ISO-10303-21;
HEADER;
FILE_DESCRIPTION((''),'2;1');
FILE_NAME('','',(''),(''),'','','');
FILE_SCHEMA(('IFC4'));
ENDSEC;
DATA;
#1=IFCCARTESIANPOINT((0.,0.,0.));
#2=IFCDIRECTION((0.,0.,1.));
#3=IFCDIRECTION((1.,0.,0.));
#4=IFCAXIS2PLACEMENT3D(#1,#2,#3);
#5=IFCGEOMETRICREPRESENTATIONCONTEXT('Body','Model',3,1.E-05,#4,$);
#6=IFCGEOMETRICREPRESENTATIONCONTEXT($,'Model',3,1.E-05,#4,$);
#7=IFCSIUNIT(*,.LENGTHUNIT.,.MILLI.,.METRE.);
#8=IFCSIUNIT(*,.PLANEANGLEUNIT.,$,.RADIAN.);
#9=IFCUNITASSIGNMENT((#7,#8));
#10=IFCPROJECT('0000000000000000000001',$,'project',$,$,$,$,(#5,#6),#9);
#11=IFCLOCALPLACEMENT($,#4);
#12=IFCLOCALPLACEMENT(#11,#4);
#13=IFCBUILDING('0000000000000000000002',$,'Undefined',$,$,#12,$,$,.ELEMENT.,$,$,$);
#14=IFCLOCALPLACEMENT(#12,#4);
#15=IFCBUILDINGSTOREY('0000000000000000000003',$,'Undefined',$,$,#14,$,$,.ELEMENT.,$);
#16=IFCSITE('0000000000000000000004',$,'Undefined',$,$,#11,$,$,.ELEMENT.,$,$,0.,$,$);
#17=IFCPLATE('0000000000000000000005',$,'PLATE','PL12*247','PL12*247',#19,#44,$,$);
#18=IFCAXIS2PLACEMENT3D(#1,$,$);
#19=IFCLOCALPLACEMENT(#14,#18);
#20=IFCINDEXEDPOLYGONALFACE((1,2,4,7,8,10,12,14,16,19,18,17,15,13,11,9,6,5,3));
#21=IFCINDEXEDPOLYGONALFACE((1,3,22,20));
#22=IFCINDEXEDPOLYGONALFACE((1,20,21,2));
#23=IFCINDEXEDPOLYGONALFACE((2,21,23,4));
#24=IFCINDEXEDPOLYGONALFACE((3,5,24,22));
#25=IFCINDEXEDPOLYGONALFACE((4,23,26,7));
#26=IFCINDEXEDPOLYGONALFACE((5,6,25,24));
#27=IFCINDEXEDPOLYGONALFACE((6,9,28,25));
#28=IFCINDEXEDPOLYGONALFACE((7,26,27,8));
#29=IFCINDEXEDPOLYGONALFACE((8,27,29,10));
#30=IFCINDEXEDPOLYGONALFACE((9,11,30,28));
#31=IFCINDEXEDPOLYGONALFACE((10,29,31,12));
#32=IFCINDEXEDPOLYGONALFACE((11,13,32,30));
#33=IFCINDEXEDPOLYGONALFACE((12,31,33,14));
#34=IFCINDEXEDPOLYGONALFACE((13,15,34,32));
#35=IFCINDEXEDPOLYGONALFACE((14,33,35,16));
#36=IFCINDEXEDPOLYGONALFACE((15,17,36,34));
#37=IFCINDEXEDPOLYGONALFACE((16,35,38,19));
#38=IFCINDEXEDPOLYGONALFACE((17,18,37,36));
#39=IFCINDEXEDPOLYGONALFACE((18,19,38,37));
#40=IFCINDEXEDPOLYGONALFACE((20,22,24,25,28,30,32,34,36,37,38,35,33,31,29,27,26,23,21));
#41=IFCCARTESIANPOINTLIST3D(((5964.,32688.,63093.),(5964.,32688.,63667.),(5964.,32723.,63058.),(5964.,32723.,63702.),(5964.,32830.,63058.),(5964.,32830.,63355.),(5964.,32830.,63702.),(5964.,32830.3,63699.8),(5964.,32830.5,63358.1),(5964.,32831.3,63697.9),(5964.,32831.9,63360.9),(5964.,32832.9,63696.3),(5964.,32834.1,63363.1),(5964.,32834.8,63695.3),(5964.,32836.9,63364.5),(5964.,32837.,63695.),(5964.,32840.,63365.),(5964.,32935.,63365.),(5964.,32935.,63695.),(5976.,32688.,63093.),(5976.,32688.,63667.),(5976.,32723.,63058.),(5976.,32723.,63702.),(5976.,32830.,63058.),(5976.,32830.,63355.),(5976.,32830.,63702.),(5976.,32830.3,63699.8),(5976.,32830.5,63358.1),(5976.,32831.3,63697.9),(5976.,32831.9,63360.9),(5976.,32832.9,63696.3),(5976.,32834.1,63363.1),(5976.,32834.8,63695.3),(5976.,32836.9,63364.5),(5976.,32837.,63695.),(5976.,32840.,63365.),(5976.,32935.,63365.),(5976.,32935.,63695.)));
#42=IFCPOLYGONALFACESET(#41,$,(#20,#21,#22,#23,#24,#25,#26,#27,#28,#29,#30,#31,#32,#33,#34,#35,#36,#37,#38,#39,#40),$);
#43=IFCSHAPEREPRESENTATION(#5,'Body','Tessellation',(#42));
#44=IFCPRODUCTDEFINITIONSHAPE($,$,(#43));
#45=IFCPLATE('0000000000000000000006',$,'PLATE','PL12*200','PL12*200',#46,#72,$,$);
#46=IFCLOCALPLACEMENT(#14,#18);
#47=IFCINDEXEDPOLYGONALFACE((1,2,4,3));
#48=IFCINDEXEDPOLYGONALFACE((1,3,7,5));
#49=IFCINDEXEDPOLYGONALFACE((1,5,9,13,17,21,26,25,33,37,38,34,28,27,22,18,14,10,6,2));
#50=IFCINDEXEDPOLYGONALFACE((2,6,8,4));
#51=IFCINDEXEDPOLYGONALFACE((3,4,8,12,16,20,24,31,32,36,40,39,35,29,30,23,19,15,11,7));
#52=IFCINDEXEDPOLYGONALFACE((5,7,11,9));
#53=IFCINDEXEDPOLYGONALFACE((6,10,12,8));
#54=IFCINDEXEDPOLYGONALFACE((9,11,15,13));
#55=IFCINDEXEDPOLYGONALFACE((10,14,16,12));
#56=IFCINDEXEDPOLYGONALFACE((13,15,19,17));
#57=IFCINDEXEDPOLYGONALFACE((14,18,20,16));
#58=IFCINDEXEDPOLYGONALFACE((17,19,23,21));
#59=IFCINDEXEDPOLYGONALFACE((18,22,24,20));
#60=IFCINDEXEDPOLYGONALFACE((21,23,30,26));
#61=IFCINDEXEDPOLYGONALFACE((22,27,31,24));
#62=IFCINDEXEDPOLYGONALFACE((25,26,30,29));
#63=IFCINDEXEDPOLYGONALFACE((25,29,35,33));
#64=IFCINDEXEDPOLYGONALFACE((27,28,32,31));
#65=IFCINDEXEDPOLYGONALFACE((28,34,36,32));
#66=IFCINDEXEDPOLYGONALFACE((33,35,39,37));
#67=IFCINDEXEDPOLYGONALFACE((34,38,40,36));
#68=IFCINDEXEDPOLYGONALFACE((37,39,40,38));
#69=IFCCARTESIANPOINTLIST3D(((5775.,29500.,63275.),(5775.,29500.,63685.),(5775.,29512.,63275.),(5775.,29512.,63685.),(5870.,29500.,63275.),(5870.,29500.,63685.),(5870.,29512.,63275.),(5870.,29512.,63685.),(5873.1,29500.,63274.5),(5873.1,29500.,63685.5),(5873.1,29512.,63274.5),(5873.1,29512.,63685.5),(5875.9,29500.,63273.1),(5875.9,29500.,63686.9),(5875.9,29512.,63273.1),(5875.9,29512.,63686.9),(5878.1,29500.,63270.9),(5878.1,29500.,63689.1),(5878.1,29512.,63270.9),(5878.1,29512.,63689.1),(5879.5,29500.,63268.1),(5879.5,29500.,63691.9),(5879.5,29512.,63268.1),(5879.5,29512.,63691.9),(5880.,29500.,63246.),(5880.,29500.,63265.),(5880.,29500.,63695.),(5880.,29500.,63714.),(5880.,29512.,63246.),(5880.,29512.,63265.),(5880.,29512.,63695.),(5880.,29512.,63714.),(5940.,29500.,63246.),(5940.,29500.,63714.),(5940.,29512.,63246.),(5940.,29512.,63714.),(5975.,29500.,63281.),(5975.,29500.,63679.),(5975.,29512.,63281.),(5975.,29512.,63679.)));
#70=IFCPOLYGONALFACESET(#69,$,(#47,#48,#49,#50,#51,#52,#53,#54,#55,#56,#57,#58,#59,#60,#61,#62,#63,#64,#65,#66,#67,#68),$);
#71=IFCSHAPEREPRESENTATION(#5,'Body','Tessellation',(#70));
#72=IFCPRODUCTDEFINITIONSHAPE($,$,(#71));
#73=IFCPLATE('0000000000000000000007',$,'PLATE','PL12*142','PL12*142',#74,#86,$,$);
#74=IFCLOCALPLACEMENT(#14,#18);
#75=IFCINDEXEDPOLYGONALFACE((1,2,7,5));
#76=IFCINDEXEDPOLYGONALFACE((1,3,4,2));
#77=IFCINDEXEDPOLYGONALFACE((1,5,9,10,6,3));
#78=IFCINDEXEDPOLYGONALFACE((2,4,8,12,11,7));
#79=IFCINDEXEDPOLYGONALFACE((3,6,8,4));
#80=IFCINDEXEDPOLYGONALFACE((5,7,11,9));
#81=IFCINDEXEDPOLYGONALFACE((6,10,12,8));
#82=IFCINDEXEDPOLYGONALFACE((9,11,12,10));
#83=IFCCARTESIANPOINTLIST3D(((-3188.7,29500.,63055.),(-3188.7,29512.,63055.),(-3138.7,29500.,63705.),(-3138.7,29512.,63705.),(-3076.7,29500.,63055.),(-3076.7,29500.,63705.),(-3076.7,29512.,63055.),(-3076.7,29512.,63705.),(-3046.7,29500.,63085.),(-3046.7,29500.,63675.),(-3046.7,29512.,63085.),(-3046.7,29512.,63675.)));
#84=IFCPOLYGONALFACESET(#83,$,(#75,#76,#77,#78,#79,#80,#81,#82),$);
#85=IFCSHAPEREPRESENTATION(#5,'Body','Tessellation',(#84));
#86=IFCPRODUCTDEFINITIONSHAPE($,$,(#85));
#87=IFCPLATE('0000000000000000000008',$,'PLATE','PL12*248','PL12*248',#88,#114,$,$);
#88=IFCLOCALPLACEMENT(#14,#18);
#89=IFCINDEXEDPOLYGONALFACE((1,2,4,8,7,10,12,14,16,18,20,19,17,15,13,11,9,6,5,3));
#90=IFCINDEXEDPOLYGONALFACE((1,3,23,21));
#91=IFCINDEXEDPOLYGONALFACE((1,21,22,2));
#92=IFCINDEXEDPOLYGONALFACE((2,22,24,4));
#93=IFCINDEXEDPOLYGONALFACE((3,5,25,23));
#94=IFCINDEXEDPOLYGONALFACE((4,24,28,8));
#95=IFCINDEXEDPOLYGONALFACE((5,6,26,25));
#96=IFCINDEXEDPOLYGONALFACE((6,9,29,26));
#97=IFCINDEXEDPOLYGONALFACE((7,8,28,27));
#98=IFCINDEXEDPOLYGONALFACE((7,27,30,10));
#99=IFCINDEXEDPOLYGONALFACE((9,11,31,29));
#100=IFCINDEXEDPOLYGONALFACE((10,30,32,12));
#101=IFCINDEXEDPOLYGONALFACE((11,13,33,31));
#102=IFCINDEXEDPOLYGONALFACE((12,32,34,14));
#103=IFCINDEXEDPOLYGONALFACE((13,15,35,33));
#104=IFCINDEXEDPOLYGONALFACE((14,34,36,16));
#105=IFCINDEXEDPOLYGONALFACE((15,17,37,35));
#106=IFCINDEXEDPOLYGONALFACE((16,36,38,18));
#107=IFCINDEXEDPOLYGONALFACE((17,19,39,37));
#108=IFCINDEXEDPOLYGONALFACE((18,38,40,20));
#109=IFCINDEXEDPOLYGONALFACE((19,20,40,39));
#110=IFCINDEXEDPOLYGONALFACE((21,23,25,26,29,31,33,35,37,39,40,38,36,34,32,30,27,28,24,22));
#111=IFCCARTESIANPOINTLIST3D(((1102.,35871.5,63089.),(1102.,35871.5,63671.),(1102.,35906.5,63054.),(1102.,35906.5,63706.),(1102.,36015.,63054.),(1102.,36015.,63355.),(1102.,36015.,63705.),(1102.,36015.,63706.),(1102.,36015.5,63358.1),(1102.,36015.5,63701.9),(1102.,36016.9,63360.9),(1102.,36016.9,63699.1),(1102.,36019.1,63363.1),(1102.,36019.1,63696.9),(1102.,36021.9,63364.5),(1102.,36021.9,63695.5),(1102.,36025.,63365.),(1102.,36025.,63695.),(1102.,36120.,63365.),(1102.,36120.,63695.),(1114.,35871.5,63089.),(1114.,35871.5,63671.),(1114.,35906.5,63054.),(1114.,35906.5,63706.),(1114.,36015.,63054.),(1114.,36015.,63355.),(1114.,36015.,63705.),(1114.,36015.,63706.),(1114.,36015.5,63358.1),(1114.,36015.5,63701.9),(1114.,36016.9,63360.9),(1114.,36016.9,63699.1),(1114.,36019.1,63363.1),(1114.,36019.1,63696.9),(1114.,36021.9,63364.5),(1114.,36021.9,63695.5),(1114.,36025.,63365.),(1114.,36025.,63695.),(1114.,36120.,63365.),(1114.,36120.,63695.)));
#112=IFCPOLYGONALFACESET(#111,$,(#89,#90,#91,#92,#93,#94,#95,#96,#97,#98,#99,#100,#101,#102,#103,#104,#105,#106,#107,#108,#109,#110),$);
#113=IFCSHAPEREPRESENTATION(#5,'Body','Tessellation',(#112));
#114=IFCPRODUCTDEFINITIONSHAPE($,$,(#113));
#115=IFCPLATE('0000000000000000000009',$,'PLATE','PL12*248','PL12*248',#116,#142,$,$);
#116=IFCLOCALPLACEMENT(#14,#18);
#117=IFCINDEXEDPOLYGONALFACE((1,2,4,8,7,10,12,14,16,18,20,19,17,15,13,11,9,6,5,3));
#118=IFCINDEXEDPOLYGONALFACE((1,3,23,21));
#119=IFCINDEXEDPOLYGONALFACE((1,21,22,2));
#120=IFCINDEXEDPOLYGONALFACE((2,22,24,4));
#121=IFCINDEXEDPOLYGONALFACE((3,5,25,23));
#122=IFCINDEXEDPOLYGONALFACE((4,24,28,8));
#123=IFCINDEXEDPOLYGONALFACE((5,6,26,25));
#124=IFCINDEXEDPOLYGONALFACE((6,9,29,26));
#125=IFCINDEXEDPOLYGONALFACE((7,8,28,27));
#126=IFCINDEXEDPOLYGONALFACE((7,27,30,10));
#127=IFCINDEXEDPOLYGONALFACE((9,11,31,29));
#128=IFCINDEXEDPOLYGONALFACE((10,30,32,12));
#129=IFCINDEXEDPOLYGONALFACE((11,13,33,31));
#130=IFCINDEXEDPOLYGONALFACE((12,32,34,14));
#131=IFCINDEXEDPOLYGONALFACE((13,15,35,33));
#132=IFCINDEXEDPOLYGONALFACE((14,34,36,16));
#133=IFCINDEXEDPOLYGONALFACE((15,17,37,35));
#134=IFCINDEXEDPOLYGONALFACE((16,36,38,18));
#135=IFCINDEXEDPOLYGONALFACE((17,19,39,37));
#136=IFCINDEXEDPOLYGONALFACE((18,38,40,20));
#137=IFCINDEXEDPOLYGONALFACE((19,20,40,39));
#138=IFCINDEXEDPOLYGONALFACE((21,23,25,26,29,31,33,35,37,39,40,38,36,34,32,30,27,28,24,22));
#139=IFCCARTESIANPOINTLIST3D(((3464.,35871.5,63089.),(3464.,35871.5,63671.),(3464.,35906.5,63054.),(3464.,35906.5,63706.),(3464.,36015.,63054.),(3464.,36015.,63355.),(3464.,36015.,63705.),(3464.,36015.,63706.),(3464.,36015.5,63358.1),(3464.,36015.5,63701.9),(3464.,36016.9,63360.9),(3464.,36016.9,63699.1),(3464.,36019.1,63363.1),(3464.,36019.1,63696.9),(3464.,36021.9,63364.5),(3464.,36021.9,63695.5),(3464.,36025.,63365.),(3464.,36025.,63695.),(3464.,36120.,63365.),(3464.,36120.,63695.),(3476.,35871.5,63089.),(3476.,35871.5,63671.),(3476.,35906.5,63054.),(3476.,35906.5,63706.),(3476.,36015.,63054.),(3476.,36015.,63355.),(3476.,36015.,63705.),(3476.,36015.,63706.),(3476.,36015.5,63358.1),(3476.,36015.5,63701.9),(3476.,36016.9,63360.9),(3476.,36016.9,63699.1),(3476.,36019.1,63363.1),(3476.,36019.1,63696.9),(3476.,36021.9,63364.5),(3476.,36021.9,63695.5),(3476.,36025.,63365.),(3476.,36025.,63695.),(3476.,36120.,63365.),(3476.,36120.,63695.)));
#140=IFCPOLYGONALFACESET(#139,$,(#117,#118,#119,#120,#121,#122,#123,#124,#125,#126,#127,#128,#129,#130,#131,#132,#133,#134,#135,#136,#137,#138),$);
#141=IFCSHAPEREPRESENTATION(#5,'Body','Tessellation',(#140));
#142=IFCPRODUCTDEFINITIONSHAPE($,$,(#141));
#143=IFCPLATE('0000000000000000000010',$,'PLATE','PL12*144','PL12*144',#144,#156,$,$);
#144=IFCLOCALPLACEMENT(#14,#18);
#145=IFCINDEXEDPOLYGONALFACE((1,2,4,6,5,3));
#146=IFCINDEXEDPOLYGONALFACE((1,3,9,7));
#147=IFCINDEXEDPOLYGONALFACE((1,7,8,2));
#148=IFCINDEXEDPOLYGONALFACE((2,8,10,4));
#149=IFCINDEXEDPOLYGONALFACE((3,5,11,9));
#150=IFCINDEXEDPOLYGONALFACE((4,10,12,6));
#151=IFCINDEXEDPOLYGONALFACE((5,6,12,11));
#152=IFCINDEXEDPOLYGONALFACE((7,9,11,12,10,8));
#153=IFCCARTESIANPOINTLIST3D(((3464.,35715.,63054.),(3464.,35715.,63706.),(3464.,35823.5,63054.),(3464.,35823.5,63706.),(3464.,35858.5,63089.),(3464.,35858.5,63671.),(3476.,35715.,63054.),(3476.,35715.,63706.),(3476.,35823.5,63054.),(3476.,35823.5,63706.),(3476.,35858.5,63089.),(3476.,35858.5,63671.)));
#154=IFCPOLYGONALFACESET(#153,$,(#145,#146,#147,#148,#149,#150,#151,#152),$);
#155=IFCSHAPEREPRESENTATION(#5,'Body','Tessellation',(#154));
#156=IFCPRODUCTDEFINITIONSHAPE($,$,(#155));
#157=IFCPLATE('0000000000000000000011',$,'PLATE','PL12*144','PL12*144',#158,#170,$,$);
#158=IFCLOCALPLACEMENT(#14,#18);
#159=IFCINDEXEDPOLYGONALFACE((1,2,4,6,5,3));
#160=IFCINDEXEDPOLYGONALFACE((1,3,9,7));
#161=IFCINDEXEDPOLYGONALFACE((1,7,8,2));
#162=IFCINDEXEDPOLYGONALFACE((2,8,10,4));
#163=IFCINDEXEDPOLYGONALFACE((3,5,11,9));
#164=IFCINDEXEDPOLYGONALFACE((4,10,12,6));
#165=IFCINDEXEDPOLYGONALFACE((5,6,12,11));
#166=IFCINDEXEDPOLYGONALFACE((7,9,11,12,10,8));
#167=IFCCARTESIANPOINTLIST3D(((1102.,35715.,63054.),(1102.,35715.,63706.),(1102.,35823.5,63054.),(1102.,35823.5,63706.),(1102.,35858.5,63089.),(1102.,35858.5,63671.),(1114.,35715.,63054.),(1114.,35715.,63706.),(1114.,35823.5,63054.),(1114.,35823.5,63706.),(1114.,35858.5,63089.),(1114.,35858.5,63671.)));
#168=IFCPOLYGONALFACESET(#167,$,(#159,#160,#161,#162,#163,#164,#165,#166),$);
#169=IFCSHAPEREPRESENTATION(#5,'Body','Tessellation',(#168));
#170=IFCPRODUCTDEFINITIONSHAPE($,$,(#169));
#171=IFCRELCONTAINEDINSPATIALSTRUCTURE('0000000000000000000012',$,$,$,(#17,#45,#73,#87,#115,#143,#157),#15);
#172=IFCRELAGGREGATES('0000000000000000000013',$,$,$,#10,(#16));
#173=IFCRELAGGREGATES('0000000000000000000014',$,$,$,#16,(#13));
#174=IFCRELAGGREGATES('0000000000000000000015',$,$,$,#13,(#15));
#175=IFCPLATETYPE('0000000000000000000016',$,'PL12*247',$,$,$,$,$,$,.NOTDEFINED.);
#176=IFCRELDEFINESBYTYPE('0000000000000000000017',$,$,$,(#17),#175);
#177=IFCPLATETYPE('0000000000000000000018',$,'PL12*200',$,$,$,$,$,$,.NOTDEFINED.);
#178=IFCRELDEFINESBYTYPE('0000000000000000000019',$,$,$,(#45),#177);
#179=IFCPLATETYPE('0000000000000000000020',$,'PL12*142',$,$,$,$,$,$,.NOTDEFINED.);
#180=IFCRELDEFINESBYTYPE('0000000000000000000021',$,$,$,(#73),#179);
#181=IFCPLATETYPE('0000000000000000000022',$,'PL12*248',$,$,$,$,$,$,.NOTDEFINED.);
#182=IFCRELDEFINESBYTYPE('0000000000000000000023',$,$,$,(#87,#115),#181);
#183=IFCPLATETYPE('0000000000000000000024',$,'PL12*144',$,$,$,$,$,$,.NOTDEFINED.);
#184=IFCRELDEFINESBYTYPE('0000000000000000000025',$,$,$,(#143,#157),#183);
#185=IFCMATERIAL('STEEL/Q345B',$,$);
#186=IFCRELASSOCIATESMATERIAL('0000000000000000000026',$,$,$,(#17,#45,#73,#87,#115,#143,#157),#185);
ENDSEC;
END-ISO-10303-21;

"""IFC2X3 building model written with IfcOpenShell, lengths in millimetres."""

from ifc_helpers import new_model, si_unit, frame, origin_with_axes, place, context, project, spatial, polyline, outline, extrude, material, type_object, element, save


model = new_model("IFC2X3")

# Units and contexts
model_context_1 = context("Model", 3, precision=1e-05, world=origin_with_axes(), identifier="Body")
model_context_2 = context("Model", 3, precision=1e-05, world=origin_with_axes())
ifc_project = project(units=[si_unit("LENGTHUNIT", "METRE", prefix="MILLI"), si_unit("PLANEANGLEUNIT", "RADIAN")], contexts=[model_context_1, model_context_2])

# Site, building, storey
site_placement = place(None, origin_with_axes())
site = spatial("IfcSite", under=ifc_project, at=site_placement, Name="Undefined", CompositionType="ELEMENT", RefElevation=0.0)
building_placement = place(site_placement, origin_with_axes())
building = spatial("IfcBuilding", under=site, at=building_placement, Name="Undefined", CompositionType="ELEMENT")
storey_placement = place(building_placement, origin_with_axes())
storey = spatial("IfcBuildingStorey", under=building, at=storey_placement, Name="Undefined", CompositionType="ELEMENT")

# Shared definitions
ifc_material_1 = material(Name="STEEL/Q345B")

# Plates
plate_type_1 = type_object("IfcPlateType", Name="PL12*247", PredefinedType="NOTDEFINED")
for number, where, z_axis, x_axis, name in (
    (1, (5970.0, 32688.0, 63093.0), (1.0, 0.0, 0.0), (0.0, 0.707107, -0.707107), "PLATE"),
):
    element("IfcPlate", number, at=place(storey_placement, frame(where, z_axis=z_axis, x_axis=x_axis)), inside=storey, type_object=plate_type_1, material=ifc_material_1, Name=name, Description="PL12*247", ObjectType="PL12*247", context=model_context_1, shape_type="SweptSolid", body=[
        extrude(outline(polyline([(0.0, 0.0), (49.5, 0.0), (125.2, 75.7), (-84.9, 285.7), (-86.7, 288.2), (-87.7, 291.2), (-87.7, 294.3), (-86.7, 297.3), (-84.9, 299.8), (-17.7, 367.0), (-251.0, 600.3), (-320.3, 531.0), (-322.1, 529.7), (-324.2, 529.1), (-326.4, 529.1), (-328.4, 529.7), (-330.2, 531.0), (-405.9, 455.4), (-405.9, 405.9), (0.0, 0.0)])), frame((0.0, 0.0, -6.0), z_axis=(0.0, 0.0, 1.0), x_axis=(1.0, 0.0, 0.0)), (0.0, 0.0, 1.0), 12.0),
    ])
plate_type_2 = type_object("IfcPlateType", Name="PL12*200", PredefinedType="NOTDEFINED")
plate_1_placement = place(storey_placement, frame((5975.0, 29506.0, 63281.0), z_axis=(0.0, 1.0, 0.0), x_axis=(-0.707107, 0.0, -0.707107)))
element("IfcPlate", 2, at=plate_1_placement, inside=storey, type_object=plate_type_2, material=ifc_material_1, Name="PLATE", Description="PL12*200", ObjectType="PL12*200", context=model_context_1, shape_type="SweptSolid", body=[
    extrude(outline(polyline([(0.0, 0.0), (49.5, 0.0), (91.9, 42.4), (78.5, 55.9), (76.6, 58.4), (75.7, 61.4), (75.7, 64.5), (76.6, 67.5), (78.5, 70.0), (145.7, 137.2), (-144.2, 427.1), (-211.4, 359.9), (-214.0, 358.1), (-216.9, 357.1), (-220.1, 357.1), (-223.0, 358.1), (-225.6, 359.9), (-239.0, 373.4), (-281.4, 330.9), (-281.4, 281.4), (0.0, 0.0)])), frame((0.0, 0.0, -6.0), z_axis=(0.0, 0.0, 1.0), x_axis=(1.0, 0.0, 0.0)), (0.0, 0.0, 1.0), 12.0),
])
plate_type_3 = type_object("IfcPlateType", Name="PL12*142", PredefinedType="NOTDEFINED")
plate_2_placement = place(storey_placement, frame((-3046.7, 29506.0, 63055.0), z_axis=(0.0, 1.0, 0.0), x_axis=(-1.0, 0.0, 0.0)))
element("IfcPlate", 3, at=plate_2_placement, inside=storey, type_object=plate_type_3, material=ifc_material_1, Name="PLATE", Description="PL12*142", ObjectType="PL12*142", context=model_context_1, shape_type="SweptSolid", body=[
    extrude(outline(polyline([(0.0, 30.0), (30.0, 0.0), (142.0, 0.0), (92.0, 650.0), (30.0, 650.0), (0.0, 620.0), (0.0, 30.0)])), frame((0.0, 0.0, -6.0), z_axis=(0.0, 0.0, 1.0), x_axis=(1.0, 0.0, 0.0)), (0.0, 0.0, 1.0), 12.0),
])
plate_type_4 = type_object("IfcPlateType", Name="PL12*248", PredefinedType="NOTDEFINED")
for number, where, z_axis, x_axis, name in (
    (4, (1108.0, 35871.5, 63089.0), (1.0, 0.0, 0.0), (0.0, 0.707107, -0.707107), "PLATE"),
    (5, (3470.0, 35871.5, 63089.0), (1.0, 0.0, 0.0), (0.0, 0.707107, -0.707107), "PLATE"),
):
    element("IfcPlate", number, at=place(storey_placement, frame(where, z_axis=z_axis, x_axis=x_axis)), inside=storey, type_object=plate_type_4, material=ifc_material_1, Name=name, Description="PL12*248", ObjectType="PL12*248", context=model_context_1, shape_type="SweptSolid", body=[
        extrude(outline(polyline([(0.0, 0.0), (49.5, 0.0), (126.2, 76.7), (-86.6, 289.6), (-88.5, 292.1), (-89.4, 295.1), (-89.4, 298.2), (-88.5, 301.2), (-86.6, 303.7), (-19.4, 370.9), (-252.8, 604.2), (-320.0, 537.0), (-322.5, 535.2), (-325.5, 534.2), (-328.6, 534.2), (-331.6, 535.2), (-334.1, 537.0), (-334.8, 537.8), (-411.5, 461.0), (-411.5, 411.5), (0.0, 0.0)])), frame((0.0, 0.0, -6.0), z_axis=(0.0, 0.0, 1.0), x_axis=(1.0, 0.0, 0.0)), (0.0, 0.0, 1.0), 12.0),
    ])
plate_type_5 = type_object("IfcPlateType", Name="PL12*144", PredefinedType="NOTDEFINED")
for number, where, z_axis, x_axis, name in (
    (6, (3470.0, 35858.5, 63054.0), (-1.0, 0.0, 0.0), (0.0, -1.0, 0.0), "PLATE"),
    (7, (1108.0, 35858.5, 63054.0), (-1.0, 0.0, 0.0), (0.0, -1.0, 0.0), "PLATE"),
):
    element("IfcPlate", number, at=place(storey_placement, frame(where, z_axis=z_axis, x_axis=x_axis)), inside=storey, type_object=plate_type_5, material=ifc_material_1, Name=name, Description="PL12*144", ObjectType="PL12*144", context=model_context_1, shape_type="SweptSolid", body=[
        extrude(outline(polyline([(0.0, 35.0), (35.0, 0.0), (143.5, 0.0), (143.5, 652.0), (35.0, 652.0), (0.0, 617.0), (0.0, 35.0)])), frame((0.0, 0.0, -6.0), z_axis=(0.0, 0.0, 1.0), x_axis=(1.0, 0.0, 0.0)), (0.0, 0.0, 1.0), 12.0),
    ])

save(model, "model.ifc")
